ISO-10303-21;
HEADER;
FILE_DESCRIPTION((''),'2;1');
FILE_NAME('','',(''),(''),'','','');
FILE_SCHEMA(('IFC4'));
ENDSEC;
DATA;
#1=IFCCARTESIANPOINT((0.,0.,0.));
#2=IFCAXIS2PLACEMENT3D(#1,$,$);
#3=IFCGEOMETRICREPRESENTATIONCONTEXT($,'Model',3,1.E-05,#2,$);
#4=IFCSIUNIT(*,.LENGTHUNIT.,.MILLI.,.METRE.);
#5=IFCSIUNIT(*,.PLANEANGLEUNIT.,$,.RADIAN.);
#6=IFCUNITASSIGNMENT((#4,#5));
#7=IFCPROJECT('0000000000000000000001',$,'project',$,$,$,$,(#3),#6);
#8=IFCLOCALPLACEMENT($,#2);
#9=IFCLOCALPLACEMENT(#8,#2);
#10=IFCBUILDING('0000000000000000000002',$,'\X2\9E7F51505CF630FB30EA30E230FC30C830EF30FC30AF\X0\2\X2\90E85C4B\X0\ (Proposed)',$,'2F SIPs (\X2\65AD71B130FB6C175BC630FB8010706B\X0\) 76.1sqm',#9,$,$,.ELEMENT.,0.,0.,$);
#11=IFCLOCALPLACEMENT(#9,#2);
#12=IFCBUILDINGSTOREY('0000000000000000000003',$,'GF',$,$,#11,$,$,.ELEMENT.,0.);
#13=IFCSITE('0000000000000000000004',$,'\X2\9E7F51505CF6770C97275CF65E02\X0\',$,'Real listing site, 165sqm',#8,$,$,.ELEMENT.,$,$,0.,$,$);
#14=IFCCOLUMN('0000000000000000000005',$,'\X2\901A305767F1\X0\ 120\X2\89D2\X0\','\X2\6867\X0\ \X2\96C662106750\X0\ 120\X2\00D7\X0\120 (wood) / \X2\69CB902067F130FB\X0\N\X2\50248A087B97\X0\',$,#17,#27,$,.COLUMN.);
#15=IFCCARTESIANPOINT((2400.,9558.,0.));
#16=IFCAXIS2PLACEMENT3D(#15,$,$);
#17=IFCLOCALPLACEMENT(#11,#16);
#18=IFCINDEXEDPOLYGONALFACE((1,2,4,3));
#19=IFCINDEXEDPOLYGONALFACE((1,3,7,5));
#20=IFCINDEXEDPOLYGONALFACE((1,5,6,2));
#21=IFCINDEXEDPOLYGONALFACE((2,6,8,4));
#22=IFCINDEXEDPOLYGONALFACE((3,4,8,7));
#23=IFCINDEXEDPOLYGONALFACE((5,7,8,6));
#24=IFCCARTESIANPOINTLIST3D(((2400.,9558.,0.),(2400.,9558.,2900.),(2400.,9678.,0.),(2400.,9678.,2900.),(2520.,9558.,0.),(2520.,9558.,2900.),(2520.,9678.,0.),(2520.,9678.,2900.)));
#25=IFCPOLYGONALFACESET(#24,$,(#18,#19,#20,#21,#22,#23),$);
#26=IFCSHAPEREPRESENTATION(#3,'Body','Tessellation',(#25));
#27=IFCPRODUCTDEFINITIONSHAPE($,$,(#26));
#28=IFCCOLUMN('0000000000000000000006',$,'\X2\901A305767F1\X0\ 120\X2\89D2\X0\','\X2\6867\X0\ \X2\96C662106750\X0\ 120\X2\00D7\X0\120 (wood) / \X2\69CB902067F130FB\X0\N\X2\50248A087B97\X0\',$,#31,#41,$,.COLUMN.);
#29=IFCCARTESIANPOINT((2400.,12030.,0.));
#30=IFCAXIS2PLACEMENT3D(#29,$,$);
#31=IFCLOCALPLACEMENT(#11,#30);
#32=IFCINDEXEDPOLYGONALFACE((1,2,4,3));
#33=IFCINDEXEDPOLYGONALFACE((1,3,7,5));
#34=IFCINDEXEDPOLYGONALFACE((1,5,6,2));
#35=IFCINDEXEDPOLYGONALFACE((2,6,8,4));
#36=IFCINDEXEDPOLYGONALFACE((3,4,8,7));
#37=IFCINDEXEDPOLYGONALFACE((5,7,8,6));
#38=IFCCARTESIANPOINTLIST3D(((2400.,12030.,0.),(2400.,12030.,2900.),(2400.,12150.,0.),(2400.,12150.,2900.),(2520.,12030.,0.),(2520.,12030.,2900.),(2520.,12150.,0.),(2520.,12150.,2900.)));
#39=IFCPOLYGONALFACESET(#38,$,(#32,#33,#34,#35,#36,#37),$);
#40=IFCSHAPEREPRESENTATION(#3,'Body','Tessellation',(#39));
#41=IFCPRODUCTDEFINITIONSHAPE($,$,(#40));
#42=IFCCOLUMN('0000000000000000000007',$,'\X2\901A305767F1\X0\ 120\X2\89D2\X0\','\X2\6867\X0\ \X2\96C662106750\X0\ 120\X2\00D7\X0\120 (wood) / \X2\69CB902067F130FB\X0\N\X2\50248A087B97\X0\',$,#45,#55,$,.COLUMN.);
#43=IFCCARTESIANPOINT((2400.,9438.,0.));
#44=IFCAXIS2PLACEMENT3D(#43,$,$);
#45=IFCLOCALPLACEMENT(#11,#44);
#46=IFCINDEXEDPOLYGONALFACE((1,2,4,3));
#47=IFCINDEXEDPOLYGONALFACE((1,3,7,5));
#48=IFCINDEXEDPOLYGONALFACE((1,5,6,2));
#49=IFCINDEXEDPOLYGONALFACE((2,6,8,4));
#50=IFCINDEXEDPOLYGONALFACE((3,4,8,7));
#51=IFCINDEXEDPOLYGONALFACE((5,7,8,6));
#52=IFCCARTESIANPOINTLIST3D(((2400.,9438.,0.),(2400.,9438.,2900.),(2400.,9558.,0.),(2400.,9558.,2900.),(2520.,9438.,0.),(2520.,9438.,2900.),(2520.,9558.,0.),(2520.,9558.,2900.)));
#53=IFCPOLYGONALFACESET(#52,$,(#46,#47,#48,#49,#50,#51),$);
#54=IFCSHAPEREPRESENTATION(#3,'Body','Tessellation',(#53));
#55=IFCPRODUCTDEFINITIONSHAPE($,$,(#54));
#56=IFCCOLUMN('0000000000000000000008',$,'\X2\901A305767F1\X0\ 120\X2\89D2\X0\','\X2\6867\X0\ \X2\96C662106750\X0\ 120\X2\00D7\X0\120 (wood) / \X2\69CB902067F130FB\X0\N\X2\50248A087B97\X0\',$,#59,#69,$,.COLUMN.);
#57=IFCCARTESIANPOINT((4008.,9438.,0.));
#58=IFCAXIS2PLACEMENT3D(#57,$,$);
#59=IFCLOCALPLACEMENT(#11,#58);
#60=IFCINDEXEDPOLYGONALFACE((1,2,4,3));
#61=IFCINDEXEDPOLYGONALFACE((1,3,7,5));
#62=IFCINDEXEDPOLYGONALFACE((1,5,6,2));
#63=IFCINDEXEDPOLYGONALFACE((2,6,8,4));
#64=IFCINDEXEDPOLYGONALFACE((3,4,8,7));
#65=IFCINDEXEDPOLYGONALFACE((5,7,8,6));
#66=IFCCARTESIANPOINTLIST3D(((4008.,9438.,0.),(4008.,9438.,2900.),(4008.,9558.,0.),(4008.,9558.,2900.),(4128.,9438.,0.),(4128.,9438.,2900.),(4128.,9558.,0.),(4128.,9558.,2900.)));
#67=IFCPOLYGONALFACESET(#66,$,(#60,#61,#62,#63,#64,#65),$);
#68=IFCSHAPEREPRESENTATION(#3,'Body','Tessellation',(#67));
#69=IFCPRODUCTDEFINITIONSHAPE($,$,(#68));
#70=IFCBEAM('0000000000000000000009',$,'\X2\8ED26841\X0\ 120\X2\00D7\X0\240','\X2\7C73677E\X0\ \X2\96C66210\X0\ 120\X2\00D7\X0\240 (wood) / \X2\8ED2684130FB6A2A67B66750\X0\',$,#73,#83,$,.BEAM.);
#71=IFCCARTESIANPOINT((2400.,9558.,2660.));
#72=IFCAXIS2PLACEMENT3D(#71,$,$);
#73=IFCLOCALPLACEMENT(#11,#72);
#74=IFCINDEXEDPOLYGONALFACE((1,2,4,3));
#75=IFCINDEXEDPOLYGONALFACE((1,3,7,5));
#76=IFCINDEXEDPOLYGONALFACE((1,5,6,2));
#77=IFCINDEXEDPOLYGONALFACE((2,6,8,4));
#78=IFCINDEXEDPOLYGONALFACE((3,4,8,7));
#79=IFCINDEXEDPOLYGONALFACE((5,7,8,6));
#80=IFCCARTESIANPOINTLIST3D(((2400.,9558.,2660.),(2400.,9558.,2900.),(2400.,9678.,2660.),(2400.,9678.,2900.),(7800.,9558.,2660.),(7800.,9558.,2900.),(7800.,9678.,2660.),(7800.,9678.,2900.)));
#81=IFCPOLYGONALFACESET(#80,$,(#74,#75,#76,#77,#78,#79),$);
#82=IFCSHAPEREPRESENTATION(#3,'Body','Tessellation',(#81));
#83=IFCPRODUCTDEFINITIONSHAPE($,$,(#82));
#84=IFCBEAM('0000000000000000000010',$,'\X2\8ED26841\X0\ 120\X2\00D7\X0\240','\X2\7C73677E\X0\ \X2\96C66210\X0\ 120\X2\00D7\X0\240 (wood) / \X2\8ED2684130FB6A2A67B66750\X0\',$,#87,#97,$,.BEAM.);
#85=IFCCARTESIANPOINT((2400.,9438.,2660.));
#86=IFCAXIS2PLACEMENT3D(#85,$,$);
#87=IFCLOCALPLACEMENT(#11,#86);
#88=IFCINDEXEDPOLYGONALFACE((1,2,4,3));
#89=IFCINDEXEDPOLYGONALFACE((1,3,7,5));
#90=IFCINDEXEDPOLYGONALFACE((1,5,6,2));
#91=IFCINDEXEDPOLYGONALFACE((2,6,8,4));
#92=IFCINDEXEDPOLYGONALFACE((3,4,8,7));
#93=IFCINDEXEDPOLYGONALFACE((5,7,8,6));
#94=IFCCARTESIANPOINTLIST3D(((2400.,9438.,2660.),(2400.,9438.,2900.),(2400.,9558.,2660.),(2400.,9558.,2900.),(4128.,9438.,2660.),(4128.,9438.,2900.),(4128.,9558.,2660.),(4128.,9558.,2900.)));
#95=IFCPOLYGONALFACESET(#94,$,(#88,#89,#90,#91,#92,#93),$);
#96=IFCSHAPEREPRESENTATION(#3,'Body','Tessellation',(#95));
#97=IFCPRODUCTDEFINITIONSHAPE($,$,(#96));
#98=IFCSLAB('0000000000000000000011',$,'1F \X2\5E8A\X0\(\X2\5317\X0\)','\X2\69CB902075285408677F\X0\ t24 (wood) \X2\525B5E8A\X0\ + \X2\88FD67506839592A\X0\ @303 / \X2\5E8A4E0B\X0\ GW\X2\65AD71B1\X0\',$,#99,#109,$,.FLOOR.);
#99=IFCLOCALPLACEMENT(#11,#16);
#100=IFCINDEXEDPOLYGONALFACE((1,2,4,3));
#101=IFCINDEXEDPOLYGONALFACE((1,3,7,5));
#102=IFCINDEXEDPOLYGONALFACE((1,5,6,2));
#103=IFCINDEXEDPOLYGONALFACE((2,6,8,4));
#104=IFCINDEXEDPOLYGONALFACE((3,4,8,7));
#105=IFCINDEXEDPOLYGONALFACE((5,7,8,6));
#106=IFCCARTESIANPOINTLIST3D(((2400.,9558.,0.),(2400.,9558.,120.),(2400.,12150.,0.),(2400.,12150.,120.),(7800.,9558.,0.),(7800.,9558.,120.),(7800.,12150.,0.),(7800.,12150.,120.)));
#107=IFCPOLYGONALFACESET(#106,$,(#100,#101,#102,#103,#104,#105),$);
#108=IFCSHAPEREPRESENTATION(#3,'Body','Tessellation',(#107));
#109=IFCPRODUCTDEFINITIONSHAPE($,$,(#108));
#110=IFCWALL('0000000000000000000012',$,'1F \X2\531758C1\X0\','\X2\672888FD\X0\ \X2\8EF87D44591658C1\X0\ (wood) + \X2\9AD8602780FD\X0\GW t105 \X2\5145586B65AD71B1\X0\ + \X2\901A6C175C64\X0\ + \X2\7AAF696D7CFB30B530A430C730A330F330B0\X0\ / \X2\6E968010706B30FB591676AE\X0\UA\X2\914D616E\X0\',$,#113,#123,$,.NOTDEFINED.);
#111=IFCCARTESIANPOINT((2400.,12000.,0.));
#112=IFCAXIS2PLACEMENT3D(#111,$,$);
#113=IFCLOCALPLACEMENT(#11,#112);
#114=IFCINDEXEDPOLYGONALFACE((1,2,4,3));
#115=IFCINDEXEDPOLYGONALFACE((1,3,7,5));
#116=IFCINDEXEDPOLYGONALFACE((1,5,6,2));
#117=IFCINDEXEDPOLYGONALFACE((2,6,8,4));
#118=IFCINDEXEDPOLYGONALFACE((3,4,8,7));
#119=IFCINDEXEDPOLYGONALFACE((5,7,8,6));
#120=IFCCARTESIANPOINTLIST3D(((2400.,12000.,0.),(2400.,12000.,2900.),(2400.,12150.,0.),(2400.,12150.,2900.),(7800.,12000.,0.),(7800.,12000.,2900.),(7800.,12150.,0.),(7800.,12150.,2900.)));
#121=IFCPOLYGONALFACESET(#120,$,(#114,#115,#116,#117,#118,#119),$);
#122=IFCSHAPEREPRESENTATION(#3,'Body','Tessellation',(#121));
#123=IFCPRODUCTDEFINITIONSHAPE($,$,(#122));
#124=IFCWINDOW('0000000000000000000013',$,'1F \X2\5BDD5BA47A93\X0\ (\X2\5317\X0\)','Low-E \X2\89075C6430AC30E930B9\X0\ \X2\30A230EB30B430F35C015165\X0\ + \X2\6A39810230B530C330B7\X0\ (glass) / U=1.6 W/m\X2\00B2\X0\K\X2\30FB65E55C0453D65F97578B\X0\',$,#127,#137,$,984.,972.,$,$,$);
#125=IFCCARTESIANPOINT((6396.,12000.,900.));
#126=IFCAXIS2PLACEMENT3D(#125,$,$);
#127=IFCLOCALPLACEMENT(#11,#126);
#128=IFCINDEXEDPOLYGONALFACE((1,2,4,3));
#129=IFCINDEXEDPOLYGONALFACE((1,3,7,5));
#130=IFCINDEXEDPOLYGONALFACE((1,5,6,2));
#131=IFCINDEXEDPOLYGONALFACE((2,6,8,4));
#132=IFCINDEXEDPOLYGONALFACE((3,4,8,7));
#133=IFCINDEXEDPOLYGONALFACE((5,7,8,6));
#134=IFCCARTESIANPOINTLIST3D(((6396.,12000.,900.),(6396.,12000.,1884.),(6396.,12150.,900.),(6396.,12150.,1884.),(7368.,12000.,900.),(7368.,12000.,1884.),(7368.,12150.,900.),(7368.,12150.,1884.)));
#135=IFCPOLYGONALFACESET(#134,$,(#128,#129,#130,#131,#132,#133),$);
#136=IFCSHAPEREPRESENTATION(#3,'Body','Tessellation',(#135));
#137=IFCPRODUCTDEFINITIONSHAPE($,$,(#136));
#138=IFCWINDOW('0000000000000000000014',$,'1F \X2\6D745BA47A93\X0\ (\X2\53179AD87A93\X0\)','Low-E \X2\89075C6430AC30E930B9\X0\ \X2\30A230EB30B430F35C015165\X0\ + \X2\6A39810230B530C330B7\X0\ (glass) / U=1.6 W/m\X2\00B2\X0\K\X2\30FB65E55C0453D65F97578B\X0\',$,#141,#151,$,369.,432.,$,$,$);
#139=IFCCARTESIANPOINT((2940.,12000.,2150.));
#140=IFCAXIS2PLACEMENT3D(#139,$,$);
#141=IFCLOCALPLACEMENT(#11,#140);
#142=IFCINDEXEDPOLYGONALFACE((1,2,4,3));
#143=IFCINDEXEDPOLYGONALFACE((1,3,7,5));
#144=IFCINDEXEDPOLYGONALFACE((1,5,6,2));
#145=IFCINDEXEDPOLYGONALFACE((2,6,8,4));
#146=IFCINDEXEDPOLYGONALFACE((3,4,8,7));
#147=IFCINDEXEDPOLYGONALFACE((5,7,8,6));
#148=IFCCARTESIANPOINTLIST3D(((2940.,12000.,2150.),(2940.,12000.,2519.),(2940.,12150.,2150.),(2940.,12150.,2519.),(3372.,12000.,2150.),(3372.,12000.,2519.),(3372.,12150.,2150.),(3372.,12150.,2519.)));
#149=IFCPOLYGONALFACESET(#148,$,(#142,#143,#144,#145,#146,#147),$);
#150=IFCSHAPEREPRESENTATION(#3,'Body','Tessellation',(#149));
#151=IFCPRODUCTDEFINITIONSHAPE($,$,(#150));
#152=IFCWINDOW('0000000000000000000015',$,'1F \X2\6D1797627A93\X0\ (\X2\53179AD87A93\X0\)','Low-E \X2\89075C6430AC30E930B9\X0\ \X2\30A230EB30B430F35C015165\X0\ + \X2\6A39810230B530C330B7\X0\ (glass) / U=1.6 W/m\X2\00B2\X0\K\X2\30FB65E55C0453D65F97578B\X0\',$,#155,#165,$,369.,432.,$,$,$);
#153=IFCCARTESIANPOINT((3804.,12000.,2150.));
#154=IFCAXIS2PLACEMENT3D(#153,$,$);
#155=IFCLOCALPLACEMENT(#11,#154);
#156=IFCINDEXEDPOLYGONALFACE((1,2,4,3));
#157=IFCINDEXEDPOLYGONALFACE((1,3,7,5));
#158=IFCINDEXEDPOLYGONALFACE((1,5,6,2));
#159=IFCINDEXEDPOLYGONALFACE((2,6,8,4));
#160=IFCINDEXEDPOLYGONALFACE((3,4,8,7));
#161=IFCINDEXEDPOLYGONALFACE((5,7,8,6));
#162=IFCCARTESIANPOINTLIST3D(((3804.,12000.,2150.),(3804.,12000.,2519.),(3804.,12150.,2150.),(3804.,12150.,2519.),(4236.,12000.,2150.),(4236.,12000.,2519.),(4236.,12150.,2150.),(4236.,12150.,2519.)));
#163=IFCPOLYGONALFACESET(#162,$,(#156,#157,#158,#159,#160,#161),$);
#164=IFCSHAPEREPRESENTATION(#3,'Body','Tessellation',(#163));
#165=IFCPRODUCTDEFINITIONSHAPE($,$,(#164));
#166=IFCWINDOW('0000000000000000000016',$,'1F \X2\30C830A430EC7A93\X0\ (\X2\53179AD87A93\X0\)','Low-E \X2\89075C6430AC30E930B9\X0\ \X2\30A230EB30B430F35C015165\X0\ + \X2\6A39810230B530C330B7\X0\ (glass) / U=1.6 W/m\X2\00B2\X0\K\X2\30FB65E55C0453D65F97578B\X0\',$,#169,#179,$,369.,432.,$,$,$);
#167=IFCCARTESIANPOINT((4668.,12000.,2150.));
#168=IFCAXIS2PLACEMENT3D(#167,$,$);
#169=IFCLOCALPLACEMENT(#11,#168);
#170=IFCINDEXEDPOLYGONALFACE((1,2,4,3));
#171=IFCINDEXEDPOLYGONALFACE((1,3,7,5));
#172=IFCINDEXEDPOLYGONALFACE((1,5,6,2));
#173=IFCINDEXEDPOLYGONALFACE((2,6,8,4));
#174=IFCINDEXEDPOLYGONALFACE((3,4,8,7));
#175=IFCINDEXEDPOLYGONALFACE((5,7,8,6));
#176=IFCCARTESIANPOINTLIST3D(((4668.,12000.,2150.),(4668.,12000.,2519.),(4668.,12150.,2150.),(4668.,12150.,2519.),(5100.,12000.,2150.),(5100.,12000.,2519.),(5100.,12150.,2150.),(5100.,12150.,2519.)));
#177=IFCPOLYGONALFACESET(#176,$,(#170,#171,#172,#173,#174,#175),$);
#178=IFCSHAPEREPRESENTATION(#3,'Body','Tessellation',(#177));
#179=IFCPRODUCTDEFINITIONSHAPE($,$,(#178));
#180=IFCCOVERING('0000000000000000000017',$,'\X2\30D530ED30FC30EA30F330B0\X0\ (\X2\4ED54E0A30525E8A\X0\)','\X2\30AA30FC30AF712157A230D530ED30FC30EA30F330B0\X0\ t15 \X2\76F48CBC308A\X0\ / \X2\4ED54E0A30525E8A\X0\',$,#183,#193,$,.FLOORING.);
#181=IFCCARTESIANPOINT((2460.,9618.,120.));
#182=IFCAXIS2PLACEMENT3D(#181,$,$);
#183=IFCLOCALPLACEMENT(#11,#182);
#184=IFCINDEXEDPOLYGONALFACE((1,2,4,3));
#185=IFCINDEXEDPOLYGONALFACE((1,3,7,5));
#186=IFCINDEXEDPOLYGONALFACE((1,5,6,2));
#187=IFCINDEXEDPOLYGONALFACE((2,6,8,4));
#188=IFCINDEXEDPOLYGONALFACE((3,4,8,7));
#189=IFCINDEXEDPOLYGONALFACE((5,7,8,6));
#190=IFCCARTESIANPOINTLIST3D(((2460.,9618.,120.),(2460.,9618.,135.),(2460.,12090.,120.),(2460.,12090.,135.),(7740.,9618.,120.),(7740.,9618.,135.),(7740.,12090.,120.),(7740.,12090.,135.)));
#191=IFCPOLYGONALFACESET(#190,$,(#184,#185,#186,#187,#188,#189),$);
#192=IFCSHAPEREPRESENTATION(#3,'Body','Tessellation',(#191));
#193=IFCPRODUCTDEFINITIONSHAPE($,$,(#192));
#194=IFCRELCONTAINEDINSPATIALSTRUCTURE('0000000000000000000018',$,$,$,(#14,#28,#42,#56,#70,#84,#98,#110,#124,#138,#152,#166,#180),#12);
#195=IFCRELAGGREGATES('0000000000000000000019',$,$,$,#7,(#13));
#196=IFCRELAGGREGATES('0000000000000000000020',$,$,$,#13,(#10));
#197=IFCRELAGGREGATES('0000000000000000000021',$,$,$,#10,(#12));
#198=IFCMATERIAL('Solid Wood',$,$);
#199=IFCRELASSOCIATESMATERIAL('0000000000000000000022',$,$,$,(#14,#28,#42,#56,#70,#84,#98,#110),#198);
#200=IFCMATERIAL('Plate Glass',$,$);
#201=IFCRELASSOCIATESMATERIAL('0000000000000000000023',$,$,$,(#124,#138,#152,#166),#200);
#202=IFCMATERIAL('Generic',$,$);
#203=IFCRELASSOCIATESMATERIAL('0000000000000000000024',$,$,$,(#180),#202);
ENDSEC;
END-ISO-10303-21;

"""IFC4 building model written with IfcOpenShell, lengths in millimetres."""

from ifc_helpers import new_model, si_unit, frame, frame_2d, origin, place, context, project, spatial, rectangle, extrude, material, element, fill, save


model = new_model("IFC4")

# Units and contexts
model_context = context("Model", 3, precision=1e-05, world=origin())
ifc_project = project(units=[si_unit("LENGTHUNIT", "METRE", prefix="MILLI"), si_unit("PLANEANGLEUNIT", "RADIAN")], contexts=[model_context])

# Site, building, storey
site_placement = place(None, origin())
site = spatial("IfcSite", under=ifc_project, at=site_placement, Name="鹿児島県霧島市", ObjectType="Real listing site, 165sqm", CompositionType="ELEMENT", RefElevation=0.0)
building_placement = place(site_placement, origin())
building = spatial("IfcBuilding", under=site, at=building_placement, Name="鹿児島・リモートワーク2部屋 (Proposed)", ObjectType="2F SIPs (断熱・気密・耐火) 76.1sqm", CompositionType="ELEMENT", ElevationOfRefHeight=0.0, ElevationOfTerrain=0.0)
storey_placement = place(building_placement, origin())
storey = spatial("IfcBuildingStorey", under=building, at=storey_placement, Name="GF", CompositionType="ELEMENT", Elevation=0.0)

# Columns
ifc_material_1 = material(Name="Solid Wood")
column_1_placement = place(storey_placement, frame((2400.0, 9558.0, 0.0)))
element("IfcColumn", 1, at=column_1_placement, inside=storey, material=ifc_material_1, Name="通し柱 120角", Description="桧 集成材 120×120 (wood) / 構造柱・N値計算", PredefinedType="COLUMN", context=model_context, shape_type="SweptSolid", body=[
    extrude(rectangle(XDim=120.0, YDim=120.0, at=frame_2d((60.0, 60.0))), frame((2400.0, 9558.0, 0.0)), (0.0, 0.0, 1.0), 2900.0),
])
column_2_placement = place(storey_placement, frame((2400.0, 12030.0, 0.0)))
element("IfcColumn", 2, at=column_2_placement, inside=storey, material=ifc_material_1, Name="通し柱 120角", Description="桧 集成材 120×120 (wood) / 構造柱・N値計算", PredefinedType="COLUMN", context=model_context, shape_type="SweptSolid", body=[
    extrude(rectangle(XDim=120.0, YDim=120.0, at=frame_2d((60.0, 60.0))), frame((2400.0, 12030.0, 0.0)), (0.0, 0.0, 1.0), 2900.0),
])
column_3_placement = place(storey_placement, frame((2400.0, 9438.0, 0.0)))
element("IfcColumn", 3, at=column_3_placement, inside=storey, material=ifc_material_1, Name="通し柱 120角", Description="桧 集成材 120×120 (wood) / 構造柱・N値計算", PredefinedType="COLUMN", context=model_context, shape_type="SweptSolid", body=[
    extrude(rectangle(XDim=120.0, YDim=120.0, at=frame_2d((60.0, 60.0))), frame((2400.0, 9438.0, 0.0)), (0.0, 0.0, 1.0), 2900.0),
])
column_4_placement = place(storey_placement, frame((4008.0, 9438.0, 0.0)))
element("IfcColumn", 4, at=column_4_placement, inside=storey, material=ifc_material_1, Name="通し柱 120角", Description="桧 集成材 120×120 (wood) / 構造柱・N値計算", PredefinedType="COLUMN", context=model_context, shape_type="SweptSolid", body=[
    extrude(rectangle(XDim=120.0, YDim=120.0, at=frame_2d((60.0, 60.0))), frame((4008.0, 9438.0, 0.0)), (0.0, 0.0, 1.0), 2900.0),
])

# Beams
beam_1_placement = place(storey_placement, frame((2400.0, 9558.0, 2660.0)))
element("IfcBeam", 5, at=beam_1_placement, inside=storey, material=ifc_material_1, Name="軒桁 120×240", Description="米松 集成 120×240 (wood) / 軒桁・横架材", PredefinedType="BEAM", context=model_context, shape_type="SweptSolid", body=[
    extrude(rectangle(XDim=5400.0, YDim=120.0, at=frame_2d((2700.0, 60.0))), frame((2400.0, 9558.0, 2660.0)), (0.0, 0.0, 1.0), 240.0),
])
beam_2_placement = place(storey_placement, frame((2400.0, 9438.0, 2660.0)))
element("IfcBeam", 6, at=beam_2_placement, inside=storey, material=ifc_material_1, Name="軒桁 120×240", Description="米松 集成 120×240 (wood) / 軒桁・横架材", PredefinedType="BEAM", context=model_context, shape_type="SweptSolid", body=[
    extrude(rectangle(XDim=1728.0, YDim=120.0, at=frame_2d((864.0, 60.0))), frame((2400.0, 9438.0, 2660.0)), (0.0, 0.0, 1.0), 240.0),
])

# Slab
slab_placement = place(storey_placement, frame((2400.0, 9558.0, 0.0)))
element("IfcSlab", 7, at=slab_placement, inside=storey, material=ifc_material_1, Name="1F 床(北)", Description="構造用合板 t24 (wood) 剛床 + 製材根太 @303 / 床下 GW断熱", PredefinedType="FLOOR", context=model_context, shape_type="SweptSolid", body=[
    extrude(rectangle(XDim=5400.0, YDim=2592.0, at=frame_2d((2700.0, 1296.0))), frame((2400.0, 9558.0, 0.0)), (0.0, 0.0, 1.0), 120.0),
])

# Wall, openings, windows
wall_1_placement = place(storey_placement, frame((2400.0, 12000.0, 0.0)))
wall_1 = element("IfcWall", 8, at=wall_1_placement, inside=storey, material=ifc_material_1, Name="1F 北壁", Description="木製 軸組外壁 (wood) + 高性能GW t105 充填断熱 + 通気層 + 窯業系サイディング / 準耐火・外皮UA配慮", PredefinedType="NOTDEFINED", context=model_context, shape_type="SweptSolid", body=[
    extrude(rectangle(XDim=5400.0, YDim=150.0, at=frame_2d((2700.0, 75.0))), frame((2400.0, 12000.0, 0.0)), (0.0, 0.0, 1.0), 2900.0),
])
opening_1_placement = place(storey_placement, frame((6396.0, 12000.0, 900.0)))
opening_1 = element("IfcOpeningElement", 9, at=opening_1_placement, cuts=wall_1, PredefinedType="NOTDEFINED", context=model_context, shape_type="SweptSolid", body=[
    extrude(rectangle(XDim=972.0, YDim=150.0, at=frame_2d((486.0, 75.0))), frame((6396.0, 12000.0, 900.0)), (0.0, 0.0, 1.0), 984.0),
])
opening_2_placement = place(storey_placement, frame((2940.0, 12000.0, 2150.0)))
opening_2 = element("IfcOpeningElement", 10, at=opening_2_placement, cuts=wall_1, PredefinedType="NOTDEFINED", context=model_context, shape_type="SweptSolid", body=[
    extrude(rectangle(XDim=432.0, YDim=150.0, at=frame_2d((216.0, 75.0))), frame((2940.0, 12000.0, 2150.0)), (0.0, 0.0, 1.0), 369.0),
])
opening_3_placement = place(storey_placement, frame((3804.0, 12000.0, 2150.0)))
opening_3 = element("IfcOpeningElement", 11, at=opening_3_placement, cuts=wall_1, PredefinedType="NOTDEFINED", context=model_context, shape_type="SweptSolid", body=[
    extrude(rectangle(XDim=432.0, YDim=150.0, at=frame_2d((216.0, 75.0))), frame((3804.0, 12000.0, 2150.0)), (0.0, 0.0, 1.0), 369.0),
])
opening_4_placement = place(storey_placement, frame((4668.0, 12000.0, 2150.0)))
opening_4 = element("IfcOpeningElement", 12, at=opening_4_placement, cuts=wall_1, PredefinedType="NOTDEFINED", context=model_context, shape_type="SweptSolid", body=[
    extrude(rectangle(XDim=432.0, YDim=150.0, at=frame_2d((216.0, 75.0))), frame((4668.0, 12000.0, 2150.0)), (0.0, 0.0, 1.0), 369.0),
])
ifc_material_2 = material(Name="Plate Glass")
window_1_placement = place(storey_placement, frame((6396.0, 12000.0, 900.0)))
window_1 = element("IfcWindow", 13, at=window_1_placement, inside=storey, material=ifc_material_2, Name="1F 寝室窓 (北)", Description="Low-E 複層ガラス アルゴン封入 + 樹脂サッシ (glass) / U=1.6 W/m²K・日射取得型", OverallHeight=984.0, OverallWidth=972.0, context=model_context, shape_type="SweptSolid", body=[
    extrude(rectangle(XDim=972.0, YDim=150.0, at=frame_2d((486.0, 75.0))), frame((6396.0, 12000.0, 900.0)), (0.0, 0.0, 1.0), 984.0),
])
fill(opening_1, window_1)
window_2_placement = place(storey_placement, frame((2940.0, 12000.0, 2150.0)))
window_2 = element("IfcWindow", 14, at=window_2_placement, inside=storey, material=ifc_material_2, Name="1F 浴室窓 (北高窓)", Description="Low-E 複層ガラス アルゴン封入 + 樹脂サッシ (glass) / U=1.6 W/m²K・日射取得型", OverallHeight=369.0, OverallWidth=432.0, context=model_context, shape_type="SweptSolid", body=[
    extrude(rectangle(XDim=432.0, YDim=150.0, at=frame_2d((216.0, 75.0))), frame((2940.0, 12000.0, 2150.0)), (0.0, 0.0, 1.0), 369.0),
])
fill(opening_2, window_2)
window_3_placement = place(storey_placement, frame((3804.0, 12000.0, 2150.0)))
window_3 = element("IfcWindow", 15, at=window_3_placement, inside=storey, material=ifc_material_2, Name="1F 洗面窓 (北高窓)", Description="Low-E 複層ガラス アルゴン封入 + 樹脂サッシ (glass) / U=1.6 W/m²K・日射取得型", OverallHeight=369.0, OverallWidth=432.0, context=model_context, shape_type="SweptSolid", body=[
    extrude(rectangle(XDim=432.0, YDim=150.0, at=frame_2d((216.0, 75.0))), frame((3804.0, 12000.0, 2150.0)), (0.0, 0.0, 1.0), 369.0),
])
fill(opening_3, window_3)
window_4_placement = place(storey_placement, frame((4668.0, 12000.0, 2150.0)))
window_4 = element("IfcWindow", 16, at=window_4_placement, inside=storey, material=ifc_material_2, Name="1F トイレ窓 (北高窓)", Description="Low-E 複層ガラス アルゴン封入 + 樹脂サッシ (glass) / U=1.6 W/m²K・日射取得型", OverallHeight=369.0, OverallWidth=432.0, context=model_context, shape_type="SweptSolid", body=[
    extrude(rectangle(XDim=432.0, YDim=150.0, at=frame_2d((216.0, 75.0))), frame((4668.0, 12000.0, 2150.0)), (0.0, 0.0, 1.0), 369.0),
])
fill(opening_4, window_4)

# Covering
ifc_material_3 = material(Name="Generic")
covering_1_placement = place(storey_placement, frame((2460.0, 9618.0, 120.0)))
element("IfcCovering", 17, at=covering_1_placement, inside=storey, material=ifc_material_3, Name="フローリング (仕上げ床)", Description="オーク無垢フローリング t15 直貼り / 仕上げ床", PredefinedType="FLOORING", context=model_context, shape_type="SweptSolid", body=[
    extrude(rectangle(XDim=5280.0, YDim=2472.0, at=frame_2d((2640.0, 1236.0))), frame((2460.0, 9618.0, 120.0)), (0.0, 0.0, 1.0), 15.0),
])

save(model, "model.ifc")
